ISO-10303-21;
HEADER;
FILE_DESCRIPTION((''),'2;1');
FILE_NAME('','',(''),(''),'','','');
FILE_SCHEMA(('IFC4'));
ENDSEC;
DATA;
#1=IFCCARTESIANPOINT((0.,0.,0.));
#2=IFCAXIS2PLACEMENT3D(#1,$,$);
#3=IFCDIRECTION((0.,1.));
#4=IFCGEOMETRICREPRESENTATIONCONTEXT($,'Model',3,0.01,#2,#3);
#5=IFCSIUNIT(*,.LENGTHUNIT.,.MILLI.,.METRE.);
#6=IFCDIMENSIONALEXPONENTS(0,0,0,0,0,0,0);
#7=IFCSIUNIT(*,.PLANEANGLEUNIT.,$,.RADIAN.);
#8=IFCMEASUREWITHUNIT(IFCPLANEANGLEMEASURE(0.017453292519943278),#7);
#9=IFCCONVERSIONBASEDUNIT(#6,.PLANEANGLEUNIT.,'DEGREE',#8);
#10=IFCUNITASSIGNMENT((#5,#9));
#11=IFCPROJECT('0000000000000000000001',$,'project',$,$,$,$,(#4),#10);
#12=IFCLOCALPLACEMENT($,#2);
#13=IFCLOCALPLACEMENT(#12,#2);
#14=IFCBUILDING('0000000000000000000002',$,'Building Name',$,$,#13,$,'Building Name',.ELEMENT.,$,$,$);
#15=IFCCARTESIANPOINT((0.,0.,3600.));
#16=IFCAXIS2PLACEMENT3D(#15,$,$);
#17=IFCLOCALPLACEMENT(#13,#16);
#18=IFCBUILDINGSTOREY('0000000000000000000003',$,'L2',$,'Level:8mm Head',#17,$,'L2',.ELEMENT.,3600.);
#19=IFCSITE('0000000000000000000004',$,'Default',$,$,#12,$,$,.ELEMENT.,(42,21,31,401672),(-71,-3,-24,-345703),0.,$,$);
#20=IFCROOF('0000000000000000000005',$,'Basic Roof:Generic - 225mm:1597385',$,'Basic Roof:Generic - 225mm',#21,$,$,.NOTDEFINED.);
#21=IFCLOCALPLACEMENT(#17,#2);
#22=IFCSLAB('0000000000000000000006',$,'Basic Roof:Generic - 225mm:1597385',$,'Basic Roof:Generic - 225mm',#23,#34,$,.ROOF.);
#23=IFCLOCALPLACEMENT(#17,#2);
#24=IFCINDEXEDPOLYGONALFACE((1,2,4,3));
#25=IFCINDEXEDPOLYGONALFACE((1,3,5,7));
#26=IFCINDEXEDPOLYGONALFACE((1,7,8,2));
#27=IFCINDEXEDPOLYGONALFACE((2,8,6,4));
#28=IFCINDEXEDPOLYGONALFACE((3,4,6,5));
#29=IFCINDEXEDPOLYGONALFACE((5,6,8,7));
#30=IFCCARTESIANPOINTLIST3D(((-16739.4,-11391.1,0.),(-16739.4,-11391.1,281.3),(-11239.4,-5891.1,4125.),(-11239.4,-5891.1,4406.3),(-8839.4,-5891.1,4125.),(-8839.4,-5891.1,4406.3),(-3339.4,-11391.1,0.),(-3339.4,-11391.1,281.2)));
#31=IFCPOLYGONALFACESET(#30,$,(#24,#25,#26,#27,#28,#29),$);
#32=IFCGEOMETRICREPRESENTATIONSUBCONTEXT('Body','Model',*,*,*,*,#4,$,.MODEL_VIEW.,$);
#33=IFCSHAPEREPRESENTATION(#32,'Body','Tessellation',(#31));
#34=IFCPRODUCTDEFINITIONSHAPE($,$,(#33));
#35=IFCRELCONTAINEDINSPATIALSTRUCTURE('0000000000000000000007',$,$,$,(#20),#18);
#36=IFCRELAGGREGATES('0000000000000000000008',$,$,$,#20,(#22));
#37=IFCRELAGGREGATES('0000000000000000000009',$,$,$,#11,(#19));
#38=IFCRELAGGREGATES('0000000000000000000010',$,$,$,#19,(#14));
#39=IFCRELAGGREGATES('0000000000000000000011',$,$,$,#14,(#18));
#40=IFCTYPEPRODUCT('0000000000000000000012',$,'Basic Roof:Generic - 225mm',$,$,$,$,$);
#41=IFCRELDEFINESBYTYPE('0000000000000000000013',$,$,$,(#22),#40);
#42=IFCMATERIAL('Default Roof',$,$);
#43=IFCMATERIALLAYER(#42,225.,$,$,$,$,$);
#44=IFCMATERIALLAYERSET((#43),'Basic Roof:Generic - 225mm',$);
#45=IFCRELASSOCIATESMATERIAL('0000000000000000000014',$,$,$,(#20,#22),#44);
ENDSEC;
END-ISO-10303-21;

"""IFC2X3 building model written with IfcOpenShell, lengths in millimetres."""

from ifc_helpers import new_model, entity, si_unit, converted_unit, direction, frame, origin, place, context, subcontext, project, spatial, polyline, outline, extrude, material, layer, layer_set, type_object, element, aggregate, save


model = new_model("IFC2X3")

# Units and contexts
model_context = context("Model", 3, precision=0.01, world=origin(), true_north=direction((0.0, 1.0)))
body_context = subcontext(model_context, "Body", "Model", "MODEL_VIEW")
ifc_project = project(units=[si_unit("LENGTHUNIT", "METRE", prefix="MILLI"), converted_unit("PLANEANGLEUNIT", "DEGREE", entity("IfcPlaneAngleMeasure", 0.017453292519943278), si_unit("PLANEANGLEUNIT", "RADIAN"), dimensions=[0, 0, 0, 0, 0, 0, 0])], contexts=[model_context])

# Site, building, storey
site_placement = place(None, origin())
site = spatial("IfcSite", under=ifc_project, at=site_placement, Name="Default", CompositionType="ELEMENT", RefLatitude=(42, 21, 31, 401672), RefLongitude=(-71, -3, -24, -345703), RefElevation=0.0)
building_placement = place(site_placement, origin())
building = spatial("IfcBuilding", under=site, at=building_placement, Name="Building Name", LongName="Building Name", CompositionType="ELEMENT")
storey_placement = place(building_placement, frame((0.0, 0.0, 3600.0)))
storey = spatial("IfcBuildingStorey", under=building, at=storey_placement, Name="L2", ObjectType="Level:8mm Head", LongName="L2", CompositionType="ELEMENT", Elevation=3600.0)

# Roof, slab
ifc_material = material(Name="Default Roof")
ifc_layer = layer(ifc_material, 225.0)
ifc_layer_set = layer_set([ifc_layer], Name="Basic Roof:Generic - 225mm")
roof_placement = place(storey_placement, frame((-16739.4, -11391.1, 0.0)))
roof = element("IfcRoof", 1, at=roof_placement, inside=storey, material=ifc_layer_set, Name="Basic Roof:Generic - 225mm:1597385", ObjectType="Basic Roof:Generic - 225mm", ShapeType="NOTDEFINED")
type_product = type_object("IfcTypeProduct", Name="Basic Roof:Generic - 225mm")
slab_1_placement = place(roof_placement, origin())
slab_1 = element("IfcSlab", 2, at=slab_1_placement, type_object=type_product, material=ifc_layer_set, Name="Basic Roof:Generic - 225mm:1597385", ObjectType="Basic Roof:Generic - 225mm", PredefinedType="ROOF", context=body_context, shape_type="SweptSolid", body=[
    extrude(outline(polyline([(-6700.0, -3437.5), (6700.0, -3437.5), (1200.0, 3437.5), (-1200.0, 3437.5), (-6700.0, -3437.5)])), frame((6700.0, 2750.0, 2062.5), z_axis=(0.0, -0.6, 0.8), x_axis=(1.0, 0.0, 0.0)), (0.0, 0.6, 0.8), 281.2),
])
aggregate(roof, [slab_1])

save(model, "model.ifc")
